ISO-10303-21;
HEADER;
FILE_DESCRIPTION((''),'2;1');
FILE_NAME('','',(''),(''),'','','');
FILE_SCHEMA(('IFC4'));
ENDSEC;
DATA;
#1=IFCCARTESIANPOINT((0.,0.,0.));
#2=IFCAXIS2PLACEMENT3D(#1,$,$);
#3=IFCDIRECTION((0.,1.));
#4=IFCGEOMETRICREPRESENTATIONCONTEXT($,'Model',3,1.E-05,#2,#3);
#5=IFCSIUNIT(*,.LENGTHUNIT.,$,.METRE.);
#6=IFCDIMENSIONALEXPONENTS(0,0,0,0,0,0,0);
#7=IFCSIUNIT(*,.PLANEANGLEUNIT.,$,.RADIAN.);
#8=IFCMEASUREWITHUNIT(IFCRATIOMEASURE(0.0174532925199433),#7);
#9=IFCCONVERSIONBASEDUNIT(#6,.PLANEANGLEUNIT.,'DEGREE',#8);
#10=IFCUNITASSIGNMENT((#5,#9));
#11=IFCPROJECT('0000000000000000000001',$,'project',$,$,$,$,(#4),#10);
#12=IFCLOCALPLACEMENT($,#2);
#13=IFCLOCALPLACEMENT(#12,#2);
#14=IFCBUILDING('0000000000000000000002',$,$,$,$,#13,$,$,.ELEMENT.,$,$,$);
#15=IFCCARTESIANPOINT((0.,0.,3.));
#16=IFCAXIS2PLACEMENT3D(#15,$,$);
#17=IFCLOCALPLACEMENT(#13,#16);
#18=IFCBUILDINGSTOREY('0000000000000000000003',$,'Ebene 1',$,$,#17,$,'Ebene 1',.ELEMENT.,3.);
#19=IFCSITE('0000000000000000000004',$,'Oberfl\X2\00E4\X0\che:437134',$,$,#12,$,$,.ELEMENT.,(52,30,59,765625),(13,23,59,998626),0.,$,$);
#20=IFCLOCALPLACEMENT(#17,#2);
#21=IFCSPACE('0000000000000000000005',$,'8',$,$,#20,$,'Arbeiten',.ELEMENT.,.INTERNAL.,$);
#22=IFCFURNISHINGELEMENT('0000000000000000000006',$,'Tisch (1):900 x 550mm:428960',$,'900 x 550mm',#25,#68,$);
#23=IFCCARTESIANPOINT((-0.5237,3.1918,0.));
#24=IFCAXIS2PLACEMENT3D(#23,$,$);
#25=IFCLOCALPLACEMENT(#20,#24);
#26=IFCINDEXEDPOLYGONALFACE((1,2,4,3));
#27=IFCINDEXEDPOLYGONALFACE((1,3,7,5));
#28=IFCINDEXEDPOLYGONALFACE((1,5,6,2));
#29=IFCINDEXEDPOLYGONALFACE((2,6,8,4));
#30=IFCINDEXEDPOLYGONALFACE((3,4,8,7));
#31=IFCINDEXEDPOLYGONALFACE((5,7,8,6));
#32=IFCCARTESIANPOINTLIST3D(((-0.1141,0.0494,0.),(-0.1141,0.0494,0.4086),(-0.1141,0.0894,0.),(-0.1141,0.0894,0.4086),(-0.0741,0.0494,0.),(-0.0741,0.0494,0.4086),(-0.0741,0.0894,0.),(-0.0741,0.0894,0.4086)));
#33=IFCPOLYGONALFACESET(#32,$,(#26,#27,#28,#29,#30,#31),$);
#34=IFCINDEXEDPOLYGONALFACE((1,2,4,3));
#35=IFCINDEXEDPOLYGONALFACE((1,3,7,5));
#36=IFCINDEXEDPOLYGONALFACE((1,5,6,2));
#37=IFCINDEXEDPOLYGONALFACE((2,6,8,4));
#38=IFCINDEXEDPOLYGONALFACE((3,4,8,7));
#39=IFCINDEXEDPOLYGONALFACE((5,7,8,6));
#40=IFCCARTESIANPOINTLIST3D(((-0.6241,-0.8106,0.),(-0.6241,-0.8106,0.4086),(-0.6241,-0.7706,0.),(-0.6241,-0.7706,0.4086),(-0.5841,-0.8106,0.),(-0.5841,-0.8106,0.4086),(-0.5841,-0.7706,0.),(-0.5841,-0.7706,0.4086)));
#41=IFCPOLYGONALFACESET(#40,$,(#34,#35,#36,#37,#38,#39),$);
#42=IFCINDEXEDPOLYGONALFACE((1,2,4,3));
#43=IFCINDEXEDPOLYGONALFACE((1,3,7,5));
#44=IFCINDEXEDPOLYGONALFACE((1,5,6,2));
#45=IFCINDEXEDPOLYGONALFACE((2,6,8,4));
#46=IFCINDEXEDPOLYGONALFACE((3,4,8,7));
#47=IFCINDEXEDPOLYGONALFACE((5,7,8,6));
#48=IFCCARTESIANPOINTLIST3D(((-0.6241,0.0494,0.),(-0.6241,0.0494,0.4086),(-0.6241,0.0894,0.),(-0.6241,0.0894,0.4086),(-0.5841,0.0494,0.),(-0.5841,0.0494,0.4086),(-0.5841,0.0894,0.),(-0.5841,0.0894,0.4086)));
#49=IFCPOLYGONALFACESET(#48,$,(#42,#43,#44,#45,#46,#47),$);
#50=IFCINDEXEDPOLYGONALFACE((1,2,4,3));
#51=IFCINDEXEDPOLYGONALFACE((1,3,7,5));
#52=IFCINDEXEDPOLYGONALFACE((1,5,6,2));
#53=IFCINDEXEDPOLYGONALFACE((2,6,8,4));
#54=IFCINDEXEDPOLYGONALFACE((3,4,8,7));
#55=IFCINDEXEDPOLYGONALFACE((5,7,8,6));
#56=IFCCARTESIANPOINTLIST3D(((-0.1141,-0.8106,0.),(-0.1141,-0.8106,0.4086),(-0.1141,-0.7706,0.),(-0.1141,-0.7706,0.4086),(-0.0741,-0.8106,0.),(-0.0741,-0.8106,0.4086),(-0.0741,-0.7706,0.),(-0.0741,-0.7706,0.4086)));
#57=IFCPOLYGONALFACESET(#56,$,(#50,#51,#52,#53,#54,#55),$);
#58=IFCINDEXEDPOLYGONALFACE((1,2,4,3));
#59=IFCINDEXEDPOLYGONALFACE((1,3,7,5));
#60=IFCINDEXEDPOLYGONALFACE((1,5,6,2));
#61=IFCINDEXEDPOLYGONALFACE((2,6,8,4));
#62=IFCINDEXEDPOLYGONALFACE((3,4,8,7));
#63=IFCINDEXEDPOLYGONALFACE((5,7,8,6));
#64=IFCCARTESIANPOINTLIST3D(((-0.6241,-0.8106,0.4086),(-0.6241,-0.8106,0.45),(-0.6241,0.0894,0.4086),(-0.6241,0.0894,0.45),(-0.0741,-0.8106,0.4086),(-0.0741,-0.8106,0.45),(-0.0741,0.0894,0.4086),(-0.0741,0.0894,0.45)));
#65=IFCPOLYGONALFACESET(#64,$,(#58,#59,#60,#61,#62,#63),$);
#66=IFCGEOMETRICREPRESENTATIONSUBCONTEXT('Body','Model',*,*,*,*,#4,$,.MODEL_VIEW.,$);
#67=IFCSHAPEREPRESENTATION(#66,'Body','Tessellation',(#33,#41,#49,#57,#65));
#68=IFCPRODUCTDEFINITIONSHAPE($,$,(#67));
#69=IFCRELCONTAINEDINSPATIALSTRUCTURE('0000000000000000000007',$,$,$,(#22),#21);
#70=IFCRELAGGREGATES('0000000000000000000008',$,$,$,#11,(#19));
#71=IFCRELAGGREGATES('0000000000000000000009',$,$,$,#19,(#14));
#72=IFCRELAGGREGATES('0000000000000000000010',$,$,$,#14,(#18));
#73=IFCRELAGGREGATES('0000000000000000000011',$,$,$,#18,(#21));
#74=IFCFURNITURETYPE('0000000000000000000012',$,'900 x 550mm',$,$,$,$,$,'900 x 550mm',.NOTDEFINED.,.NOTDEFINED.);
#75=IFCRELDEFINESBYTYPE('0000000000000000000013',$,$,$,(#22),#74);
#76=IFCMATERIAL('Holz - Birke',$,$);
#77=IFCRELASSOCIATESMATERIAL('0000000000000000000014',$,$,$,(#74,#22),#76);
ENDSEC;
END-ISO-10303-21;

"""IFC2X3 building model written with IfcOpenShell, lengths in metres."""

from ifc_helpers import new_model, entity, si_unit, converted_unit, direction, frame, frame_2d, origin, origin_2d_with_axis, place, context, subcontext, project, spatial, rectangle, extrude, source, transform, mapped, material, type_object, type_shapes, element, save


model = new_model("IFC2X3")

# Units and contexts
model_context = context("Model", 3, precision=1e-05, world=origin(), true_north=direction((0.0, 1.0)))
body_context = subcontext(model_context, "Body", "Model", "MODEL_VIEW")
ifc_project = project(units=[si_unit("LENGTHUNIT", "METRE"), converted_unit("PLANEANGLEUNIT", "DEGREE", entity("IfcRatioMeasure", 0.0174532925199433), si_unit("PLANEANGLEUNIT", "RADIAN"), dimensions=[0, 0, 0, 0, 0, 0, 0])], contexts=[model_context])

# Site, building, storey
site_placement = place(None, origin())
site = spatial("IfcSite", under=ifc_project, at=site_placement, Name="Oberfläche:437134", CompositionType="ELEMENT", RefLatitude=(52, 30, 59, 765625), RefLongitude=(13, 23, 59, 998626), RefElevation=0.0)
building_placement = place(site_placement, origin())
building = spatial("IfcBuilding", under=site, at=building_placement, CompositionType="ELEMENT")
storey_placement = place(building_placement, frame((0.0, 0.0, 3.0)))
storey = spatial("IfcBuildingStorey", under=building, at=storey_placement, Name="Ebene 1", LongName="Ebene 1", CompositionType="ELEMENT", Elevation=3.0)

# Shared definitions
space_placement = place(storey_placement, origin())
space = spatial("IfcSpace", under=storey, at=space_placement, Name="8", LongName="Arbeiten", CompositionType="ELEMENT", InteriorOrExteriorSpace="INTERNAL")

# Furnishing element
ifc_material_1 = material(Name="Holz - Birke")
furniture_type = type_object("IfcFurnitureType", Name="900 x 550mm", ElementType="900 x 550mm", material=ifc_material_1)
shared_shape = source(origin(), body_context, "Body", "SweptSolid", [
    extrude(rectangle(XDim=0.04, YDim=0.04, at=origin_2d_with_axis()), frame((-0.0941, 0.0694, 0.0), z_axis=(0.0, 0.0, 1.0), x_axis=(-1.0, 0.0, 0.0)), (0.0, 0.0, 1.0), 0.4086),
    extrude(rectangle(XDim=0.04, YDim=0.04, at=frame_2d((0.0, 0.0), x_axis=(1.0, 0.0))), frame((-0.6041, -0.7906, 0.0), z_axis=(0.0, 0.0, 1.0), x_axis=(0.0, -1.0, 0.0)), (0.0, 0.0, 1.0), 0.4086),
    extrude(rectangle(XDim=0.04, YDim=0.04, at=origin_2d_with_axis()), frame((-0.6041, 0.0694, 0.0), z_axis=(0.0, 0.0, 1.0), x_axis=(-1.0, 0.0, 0.0)), (0.0, 0.0, 1.0), 0.4086),
    extrude(rectangle(XDim=0.04, YDim=0.04, at=frame_2d((0.0, 0.0), x_axis=(1.0, 0.0))), frame((-0.0941, -0.7906, 0.0), z_axis=(0.0, 0.0, 1.0), x_axis=(-1.0, 0.0, 0.0)), (0.0, 0.0, 1.0), 0.4086),
    extrude(rectangle(XDim=0.55, YDim=0.9, at=frame_2d((0.0, 0.0), x_axis=(1.0, 0.0))), frame((-0.3491, -0.3606, 0.4086), z_axis=(0.0, 0.0, 1.0), x_axis=(-1.0, 0.0, 0.0)), (0.0, 0.0, 1.0), 0.0414),
])
type_shapes(furniture_type, [shared_shape])
furnishing_placement = place(space_placement, frame((-0.5237, 3.1918, 0.0)))
element("IfcFurnishingElement", 1, at=furnishing_placement, inside=space, type_object=furniture_type, material=ifc_material_1, Name="Tisch (1):900 x 550mm:428960", ObjectType="900 x 550mm", context=body_context, shape_type="MappedRepresentation", body=[
    mapped(shared_shape, transform((0.0, 0.0, 0.0), scale=1.0)),
])

save(model, "model.ifc")
